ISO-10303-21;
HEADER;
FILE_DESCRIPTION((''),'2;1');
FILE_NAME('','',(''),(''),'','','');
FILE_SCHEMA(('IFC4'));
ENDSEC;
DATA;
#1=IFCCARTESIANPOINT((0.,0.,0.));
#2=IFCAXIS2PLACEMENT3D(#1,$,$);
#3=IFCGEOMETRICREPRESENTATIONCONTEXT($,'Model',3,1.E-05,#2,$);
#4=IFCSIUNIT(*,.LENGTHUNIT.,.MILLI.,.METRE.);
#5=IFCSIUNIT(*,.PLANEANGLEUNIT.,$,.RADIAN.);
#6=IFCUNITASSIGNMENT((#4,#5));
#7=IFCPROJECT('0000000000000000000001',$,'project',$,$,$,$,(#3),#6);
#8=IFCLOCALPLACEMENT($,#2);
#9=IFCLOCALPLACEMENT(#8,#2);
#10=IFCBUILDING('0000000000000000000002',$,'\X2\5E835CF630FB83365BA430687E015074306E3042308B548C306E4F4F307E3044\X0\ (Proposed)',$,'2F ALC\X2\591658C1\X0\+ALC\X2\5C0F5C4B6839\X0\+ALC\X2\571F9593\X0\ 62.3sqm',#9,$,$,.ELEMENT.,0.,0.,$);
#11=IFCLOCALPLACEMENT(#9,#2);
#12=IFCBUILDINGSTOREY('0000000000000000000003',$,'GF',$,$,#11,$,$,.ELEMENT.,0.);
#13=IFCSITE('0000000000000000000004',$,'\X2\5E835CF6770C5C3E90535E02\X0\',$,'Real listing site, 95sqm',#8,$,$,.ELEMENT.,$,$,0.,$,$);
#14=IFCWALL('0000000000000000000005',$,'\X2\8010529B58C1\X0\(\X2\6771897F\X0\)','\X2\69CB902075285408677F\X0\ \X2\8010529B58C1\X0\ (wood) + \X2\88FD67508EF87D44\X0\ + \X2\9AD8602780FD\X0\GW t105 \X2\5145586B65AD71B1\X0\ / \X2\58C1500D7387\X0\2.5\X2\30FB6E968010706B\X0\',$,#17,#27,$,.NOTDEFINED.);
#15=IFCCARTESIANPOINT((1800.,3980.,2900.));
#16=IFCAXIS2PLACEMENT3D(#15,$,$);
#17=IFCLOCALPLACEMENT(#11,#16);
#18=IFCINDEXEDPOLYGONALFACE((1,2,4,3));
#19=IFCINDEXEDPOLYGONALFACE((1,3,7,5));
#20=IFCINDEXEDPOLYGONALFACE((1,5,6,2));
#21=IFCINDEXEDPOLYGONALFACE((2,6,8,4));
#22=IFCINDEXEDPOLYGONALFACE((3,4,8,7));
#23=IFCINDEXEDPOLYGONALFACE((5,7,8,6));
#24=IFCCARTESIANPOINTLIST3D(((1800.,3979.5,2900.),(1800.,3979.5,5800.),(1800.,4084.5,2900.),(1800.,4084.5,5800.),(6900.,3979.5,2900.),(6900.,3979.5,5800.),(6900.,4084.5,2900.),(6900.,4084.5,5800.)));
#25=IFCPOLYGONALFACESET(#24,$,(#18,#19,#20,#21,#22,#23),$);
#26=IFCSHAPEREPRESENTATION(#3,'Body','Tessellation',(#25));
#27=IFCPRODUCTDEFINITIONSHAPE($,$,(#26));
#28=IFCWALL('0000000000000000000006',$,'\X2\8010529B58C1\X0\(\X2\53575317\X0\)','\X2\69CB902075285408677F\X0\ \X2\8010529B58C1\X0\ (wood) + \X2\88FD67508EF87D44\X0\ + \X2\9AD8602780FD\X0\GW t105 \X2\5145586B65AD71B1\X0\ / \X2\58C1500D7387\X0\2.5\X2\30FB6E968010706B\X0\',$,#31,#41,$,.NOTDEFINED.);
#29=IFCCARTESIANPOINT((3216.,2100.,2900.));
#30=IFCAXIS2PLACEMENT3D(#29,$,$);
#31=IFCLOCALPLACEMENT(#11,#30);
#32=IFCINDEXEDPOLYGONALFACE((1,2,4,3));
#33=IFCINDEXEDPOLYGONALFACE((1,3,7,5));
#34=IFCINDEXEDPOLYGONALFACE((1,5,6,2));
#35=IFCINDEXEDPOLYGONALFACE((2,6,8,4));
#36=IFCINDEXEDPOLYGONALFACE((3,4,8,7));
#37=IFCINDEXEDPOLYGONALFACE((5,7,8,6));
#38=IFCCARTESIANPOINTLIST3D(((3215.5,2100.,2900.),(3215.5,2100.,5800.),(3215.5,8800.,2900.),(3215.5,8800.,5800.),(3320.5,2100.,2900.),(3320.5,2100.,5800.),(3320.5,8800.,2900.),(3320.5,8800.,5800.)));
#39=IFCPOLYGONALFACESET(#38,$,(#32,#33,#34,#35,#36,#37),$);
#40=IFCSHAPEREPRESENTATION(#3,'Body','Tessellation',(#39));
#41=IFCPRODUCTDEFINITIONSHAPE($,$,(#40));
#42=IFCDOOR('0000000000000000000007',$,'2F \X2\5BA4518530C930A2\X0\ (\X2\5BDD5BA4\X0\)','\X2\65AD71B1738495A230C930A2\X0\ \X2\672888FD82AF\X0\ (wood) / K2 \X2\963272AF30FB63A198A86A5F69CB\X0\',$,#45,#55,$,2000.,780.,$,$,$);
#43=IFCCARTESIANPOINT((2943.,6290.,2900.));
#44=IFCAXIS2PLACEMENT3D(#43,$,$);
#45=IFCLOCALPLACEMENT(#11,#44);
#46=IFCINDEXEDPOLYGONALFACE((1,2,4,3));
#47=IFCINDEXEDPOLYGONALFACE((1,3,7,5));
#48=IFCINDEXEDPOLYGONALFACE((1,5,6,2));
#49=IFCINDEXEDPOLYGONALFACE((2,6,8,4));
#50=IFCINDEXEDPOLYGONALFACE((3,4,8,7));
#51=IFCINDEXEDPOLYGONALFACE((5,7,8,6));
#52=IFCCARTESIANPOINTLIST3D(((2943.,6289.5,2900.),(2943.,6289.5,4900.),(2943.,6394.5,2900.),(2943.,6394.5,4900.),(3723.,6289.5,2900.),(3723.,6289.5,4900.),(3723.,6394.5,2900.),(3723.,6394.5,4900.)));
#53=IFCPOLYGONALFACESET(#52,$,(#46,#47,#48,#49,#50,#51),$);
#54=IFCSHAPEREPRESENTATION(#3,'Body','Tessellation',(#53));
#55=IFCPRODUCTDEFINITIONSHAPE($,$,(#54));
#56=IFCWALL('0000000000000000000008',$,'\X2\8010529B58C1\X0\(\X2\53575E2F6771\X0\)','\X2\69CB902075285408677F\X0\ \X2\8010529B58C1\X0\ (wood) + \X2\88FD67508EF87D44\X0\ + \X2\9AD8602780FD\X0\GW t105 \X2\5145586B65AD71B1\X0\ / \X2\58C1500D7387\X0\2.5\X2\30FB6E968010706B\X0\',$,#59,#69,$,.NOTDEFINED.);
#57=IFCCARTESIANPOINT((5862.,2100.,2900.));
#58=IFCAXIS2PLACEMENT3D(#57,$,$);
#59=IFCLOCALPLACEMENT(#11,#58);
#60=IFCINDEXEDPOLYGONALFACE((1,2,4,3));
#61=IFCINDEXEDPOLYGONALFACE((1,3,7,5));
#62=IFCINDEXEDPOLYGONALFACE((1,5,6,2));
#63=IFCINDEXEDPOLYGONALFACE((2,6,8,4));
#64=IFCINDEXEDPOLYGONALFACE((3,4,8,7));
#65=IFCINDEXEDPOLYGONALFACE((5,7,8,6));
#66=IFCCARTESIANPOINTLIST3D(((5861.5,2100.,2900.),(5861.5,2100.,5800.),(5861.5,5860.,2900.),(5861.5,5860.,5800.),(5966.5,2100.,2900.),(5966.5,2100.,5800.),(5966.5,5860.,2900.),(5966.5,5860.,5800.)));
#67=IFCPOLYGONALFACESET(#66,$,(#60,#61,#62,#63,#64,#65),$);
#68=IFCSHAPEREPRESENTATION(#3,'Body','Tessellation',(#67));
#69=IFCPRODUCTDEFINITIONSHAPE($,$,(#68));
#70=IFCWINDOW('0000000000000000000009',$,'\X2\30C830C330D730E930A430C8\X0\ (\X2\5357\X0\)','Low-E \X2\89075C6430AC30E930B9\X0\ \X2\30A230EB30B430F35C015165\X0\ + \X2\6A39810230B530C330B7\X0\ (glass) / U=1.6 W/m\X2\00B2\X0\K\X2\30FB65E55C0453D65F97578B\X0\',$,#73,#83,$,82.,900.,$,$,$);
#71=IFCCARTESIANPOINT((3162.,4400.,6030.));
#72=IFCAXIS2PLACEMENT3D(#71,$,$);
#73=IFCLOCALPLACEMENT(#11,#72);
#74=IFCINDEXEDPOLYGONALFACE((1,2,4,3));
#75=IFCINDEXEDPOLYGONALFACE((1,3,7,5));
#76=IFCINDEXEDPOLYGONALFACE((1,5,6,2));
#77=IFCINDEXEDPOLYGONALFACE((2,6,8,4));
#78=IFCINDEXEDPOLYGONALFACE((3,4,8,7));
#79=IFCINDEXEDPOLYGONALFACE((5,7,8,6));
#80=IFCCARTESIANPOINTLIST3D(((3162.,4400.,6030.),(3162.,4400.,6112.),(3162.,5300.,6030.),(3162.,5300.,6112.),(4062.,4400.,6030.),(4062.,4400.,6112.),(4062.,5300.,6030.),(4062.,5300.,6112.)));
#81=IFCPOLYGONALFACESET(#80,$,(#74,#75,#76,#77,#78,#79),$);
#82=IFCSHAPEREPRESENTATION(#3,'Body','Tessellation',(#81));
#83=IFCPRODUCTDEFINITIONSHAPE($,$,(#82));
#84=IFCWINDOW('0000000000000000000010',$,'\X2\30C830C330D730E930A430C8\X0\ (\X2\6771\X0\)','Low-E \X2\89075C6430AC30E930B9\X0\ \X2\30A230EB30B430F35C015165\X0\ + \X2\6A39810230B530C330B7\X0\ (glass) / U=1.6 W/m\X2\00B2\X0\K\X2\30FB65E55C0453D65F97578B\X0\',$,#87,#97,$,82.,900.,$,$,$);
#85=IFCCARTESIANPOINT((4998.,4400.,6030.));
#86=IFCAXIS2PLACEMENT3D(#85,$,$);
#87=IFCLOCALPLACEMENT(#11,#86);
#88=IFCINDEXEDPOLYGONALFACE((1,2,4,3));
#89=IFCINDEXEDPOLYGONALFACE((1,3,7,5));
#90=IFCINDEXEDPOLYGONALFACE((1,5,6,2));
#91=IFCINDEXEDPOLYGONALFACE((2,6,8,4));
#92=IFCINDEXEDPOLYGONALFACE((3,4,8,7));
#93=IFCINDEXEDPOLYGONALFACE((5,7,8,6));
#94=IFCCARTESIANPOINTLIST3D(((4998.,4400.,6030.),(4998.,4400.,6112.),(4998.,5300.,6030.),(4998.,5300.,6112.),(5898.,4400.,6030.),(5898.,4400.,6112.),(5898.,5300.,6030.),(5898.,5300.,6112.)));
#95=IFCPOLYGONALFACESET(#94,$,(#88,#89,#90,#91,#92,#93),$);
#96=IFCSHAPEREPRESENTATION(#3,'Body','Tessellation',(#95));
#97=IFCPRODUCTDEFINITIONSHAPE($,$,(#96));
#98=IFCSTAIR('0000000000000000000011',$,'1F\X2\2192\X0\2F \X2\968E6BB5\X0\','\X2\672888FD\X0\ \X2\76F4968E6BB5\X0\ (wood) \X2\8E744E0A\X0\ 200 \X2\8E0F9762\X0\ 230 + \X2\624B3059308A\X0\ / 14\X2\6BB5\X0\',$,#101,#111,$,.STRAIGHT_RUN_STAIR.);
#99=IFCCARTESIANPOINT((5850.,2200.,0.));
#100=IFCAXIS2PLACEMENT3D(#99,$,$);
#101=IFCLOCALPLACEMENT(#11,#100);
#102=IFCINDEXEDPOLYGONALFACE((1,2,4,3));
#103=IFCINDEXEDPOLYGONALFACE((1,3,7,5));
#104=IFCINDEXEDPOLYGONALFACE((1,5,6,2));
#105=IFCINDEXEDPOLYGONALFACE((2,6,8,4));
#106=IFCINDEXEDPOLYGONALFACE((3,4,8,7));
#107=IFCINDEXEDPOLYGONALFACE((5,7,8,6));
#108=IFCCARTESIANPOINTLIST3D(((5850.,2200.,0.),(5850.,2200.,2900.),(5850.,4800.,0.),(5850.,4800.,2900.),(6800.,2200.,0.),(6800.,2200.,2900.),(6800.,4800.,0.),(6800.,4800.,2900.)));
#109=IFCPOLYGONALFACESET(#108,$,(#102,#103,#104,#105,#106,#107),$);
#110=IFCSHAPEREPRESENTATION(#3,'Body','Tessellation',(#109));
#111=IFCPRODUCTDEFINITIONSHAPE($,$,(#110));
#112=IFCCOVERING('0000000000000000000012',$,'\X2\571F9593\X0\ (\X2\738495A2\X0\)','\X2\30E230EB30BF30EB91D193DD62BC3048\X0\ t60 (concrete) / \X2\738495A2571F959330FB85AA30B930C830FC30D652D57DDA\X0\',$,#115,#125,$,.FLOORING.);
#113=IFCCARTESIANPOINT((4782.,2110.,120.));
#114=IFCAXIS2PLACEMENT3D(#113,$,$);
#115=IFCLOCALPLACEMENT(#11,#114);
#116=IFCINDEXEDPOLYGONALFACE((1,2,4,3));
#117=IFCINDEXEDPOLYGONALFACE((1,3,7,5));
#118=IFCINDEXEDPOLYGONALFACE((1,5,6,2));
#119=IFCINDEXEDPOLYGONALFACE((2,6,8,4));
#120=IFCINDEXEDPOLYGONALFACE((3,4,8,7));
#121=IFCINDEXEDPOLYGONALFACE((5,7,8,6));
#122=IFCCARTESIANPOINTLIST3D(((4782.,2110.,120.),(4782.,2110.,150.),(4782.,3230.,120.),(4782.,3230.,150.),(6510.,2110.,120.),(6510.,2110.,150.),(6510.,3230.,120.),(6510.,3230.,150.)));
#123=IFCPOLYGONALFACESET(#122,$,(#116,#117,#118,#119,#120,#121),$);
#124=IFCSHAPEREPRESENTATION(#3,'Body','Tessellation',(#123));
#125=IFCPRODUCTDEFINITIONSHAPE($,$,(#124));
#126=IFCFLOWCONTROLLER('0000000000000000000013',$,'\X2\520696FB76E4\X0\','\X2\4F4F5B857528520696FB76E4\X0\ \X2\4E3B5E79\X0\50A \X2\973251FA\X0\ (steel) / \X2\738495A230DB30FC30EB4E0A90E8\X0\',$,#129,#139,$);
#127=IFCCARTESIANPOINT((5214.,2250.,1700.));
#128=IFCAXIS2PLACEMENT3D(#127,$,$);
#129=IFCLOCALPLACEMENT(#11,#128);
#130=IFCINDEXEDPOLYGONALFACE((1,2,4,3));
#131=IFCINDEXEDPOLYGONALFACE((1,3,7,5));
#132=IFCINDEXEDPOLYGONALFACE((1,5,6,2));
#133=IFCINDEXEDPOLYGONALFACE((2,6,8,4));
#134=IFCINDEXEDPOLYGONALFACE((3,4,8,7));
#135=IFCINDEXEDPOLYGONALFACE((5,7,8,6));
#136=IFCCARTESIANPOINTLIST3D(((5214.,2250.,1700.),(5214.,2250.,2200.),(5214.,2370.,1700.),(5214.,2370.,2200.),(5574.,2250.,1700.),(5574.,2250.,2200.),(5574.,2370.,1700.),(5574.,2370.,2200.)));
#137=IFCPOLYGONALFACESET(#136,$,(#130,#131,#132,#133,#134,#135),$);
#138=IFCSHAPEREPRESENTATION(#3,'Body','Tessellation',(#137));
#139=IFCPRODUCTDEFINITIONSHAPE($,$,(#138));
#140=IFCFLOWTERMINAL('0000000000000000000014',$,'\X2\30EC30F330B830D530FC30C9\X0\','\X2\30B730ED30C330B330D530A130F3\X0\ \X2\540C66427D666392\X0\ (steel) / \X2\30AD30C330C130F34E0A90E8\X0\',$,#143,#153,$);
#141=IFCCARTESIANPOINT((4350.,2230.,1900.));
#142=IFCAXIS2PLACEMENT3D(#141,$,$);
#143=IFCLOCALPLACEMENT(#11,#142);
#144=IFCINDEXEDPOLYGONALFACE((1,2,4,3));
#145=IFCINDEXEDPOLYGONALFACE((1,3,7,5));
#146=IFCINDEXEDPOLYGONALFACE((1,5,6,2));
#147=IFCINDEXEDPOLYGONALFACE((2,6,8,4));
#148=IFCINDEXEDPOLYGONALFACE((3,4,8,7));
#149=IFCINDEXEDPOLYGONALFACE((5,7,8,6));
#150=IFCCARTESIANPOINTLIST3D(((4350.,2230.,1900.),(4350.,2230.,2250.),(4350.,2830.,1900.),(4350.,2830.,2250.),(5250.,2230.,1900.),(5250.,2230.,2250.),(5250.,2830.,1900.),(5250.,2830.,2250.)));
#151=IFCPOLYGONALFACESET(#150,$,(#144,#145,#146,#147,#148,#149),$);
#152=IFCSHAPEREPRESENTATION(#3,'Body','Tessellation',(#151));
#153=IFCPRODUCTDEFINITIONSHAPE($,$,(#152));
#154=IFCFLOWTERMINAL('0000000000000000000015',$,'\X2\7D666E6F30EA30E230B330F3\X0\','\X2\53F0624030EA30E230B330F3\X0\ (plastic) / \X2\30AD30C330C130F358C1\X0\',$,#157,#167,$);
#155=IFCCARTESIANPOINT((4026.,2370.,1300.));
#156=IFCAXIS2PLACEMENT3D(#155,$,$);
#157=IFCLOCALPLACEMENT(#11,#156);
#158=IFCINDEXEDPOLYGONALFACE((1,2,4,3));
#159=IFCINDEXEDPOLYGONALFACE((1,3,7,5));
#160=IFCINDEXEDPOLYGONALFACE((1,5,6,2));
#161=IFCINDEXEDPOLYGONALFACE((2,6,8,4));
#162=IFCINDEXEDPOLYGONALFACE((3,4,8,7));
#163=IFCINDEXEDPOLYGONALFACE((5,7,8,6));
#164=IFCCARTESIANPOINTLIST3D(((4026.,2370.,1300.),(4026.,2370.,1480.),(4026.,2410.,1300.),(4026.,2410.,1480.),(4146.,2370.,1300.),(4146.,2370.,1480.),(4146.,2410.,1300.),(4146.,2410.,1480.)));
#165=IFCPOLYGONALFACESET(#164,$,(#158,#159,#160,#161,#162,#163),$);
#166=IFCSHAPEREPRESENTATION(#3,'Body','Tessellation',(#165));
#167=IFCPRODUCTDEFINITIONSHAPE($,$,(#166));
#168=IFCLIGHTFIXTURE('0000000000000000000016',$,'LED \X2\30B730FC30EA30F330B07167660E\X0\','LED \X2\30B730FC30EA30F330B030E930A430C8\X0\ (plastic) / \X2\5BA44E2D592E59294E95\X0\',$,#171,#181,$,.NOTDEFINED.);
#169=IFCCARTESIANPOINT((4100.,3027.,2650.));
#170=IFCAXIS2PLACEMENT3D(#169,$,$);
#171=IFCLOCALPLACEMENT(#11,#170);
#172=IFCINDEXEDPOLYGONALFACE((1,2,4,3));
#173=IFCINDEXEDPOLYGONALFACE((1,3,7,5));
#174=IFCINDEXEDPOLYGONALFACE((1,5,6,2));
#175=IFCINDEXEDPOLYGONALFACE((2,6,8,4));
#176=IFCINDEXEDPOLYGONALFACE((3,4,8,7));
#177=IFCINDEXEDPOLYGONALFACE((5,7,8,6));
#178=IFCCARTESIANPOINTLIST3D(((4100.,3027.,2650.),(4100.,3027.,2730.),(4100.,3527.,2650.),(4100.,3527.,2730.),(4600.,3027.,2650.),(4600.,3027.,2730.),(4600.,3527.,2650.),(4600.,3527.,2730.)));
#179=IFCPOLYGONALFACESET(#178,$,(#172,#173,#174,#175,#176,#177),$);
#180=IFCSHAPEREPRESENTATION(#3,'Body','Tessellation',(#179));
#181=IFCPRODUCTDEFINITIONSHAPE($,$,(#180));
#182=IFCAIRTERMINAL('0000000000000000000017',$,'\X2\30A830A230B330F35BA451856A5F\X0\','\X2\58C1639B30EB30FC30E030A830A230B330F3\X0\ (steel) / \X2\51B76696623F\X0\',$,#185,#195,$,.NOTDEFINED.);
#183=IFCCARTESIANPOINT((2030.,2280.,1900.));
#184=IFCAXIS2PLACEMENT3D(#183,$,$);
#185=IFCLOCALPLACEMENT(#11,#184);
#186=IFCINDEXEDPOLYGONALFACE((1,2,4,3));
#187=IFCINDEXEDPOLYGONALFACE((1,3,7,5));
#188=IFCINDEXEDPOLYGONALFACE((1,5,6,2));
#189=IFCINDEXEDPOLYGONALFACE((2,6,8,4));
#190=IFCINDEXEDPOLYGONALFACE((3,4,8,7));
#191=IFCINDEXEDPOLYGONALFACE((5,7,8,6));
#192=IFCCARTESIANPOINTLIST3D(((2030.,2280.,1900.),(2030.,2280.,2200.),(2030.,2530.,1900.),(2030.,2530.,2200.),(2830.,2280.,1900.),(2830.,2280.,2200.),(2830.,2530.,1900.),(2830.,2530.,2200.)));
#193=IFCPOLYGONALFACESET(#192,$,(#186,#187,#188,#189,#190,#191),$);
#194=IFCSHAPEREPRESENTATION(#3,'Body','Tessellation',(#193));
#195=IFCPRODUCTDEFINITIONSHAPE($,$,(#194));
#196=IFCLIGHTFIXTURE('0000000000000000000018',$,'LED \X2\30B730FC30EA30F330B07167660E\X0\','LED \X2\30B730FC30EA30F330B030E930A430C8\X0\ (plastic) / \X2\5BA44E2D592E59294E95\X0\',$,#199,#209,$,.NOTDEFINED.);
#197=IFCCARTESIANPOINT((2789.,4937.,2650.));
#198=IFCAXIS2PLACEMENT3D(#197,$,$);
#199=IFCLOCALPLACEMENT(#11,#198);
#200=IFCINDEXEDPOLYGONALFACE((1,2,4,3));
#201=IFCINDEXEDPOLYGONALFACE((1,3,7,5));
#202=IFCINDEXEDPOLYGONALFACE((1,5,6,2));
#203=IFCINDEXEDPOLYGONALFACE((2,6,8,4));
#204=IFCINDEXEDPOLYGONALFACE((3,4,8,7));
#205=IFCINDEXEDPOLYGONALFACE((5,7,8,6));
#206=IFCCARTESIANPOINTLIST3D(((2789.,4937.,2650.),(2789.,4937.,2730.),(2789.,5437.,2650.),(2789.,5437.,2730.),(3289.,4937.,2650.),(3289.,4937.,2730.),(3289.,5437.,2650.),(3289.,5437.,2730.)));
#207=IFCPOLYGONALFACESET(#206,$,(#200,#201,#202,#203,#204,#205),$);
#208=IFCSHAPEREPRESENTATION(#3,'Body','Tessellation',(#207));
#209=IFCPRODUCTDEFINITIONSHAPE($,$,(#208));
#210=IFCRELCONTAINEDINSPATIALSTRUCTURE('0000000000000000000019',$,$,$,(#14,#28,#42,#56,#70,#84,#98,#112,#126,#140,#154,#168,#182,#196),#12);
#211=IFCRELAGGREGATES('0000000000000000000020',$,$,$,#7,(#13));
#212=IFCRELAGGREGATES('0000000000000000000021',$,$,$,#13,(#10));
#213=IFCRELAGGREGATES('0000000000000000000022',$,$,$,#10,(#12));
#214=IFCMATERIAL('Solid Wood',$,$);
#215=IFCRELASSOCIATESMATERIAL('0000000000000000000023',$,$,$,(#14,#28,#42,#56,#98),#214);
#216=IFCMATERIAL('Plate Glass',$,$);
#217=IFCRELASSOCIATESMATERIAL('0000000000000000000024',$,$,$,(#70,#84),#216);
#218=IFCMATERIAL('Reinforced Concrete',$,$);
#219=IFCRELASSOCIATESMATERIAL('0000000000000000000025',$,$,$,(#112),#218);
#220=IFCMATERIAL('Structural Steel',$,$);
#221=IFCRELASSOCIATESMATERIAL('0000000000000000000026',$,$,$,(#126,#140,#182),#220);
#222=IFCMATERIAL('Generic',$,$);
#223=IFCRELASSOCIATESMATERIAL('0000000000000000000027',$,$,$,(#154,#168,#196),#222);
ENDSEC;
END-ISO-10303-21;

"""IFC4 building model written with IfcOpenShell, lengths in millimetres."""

from ifc_helpers import new_model, si_unit, frame, frame_2d, origin, place, context, project, spatial, rectangle, extrude, material, element, fill, save


model = new_model("IFC4")

# Units and contexts
model_context = context("Model", 3, precision=1e-05, world=origin())
ifc_project = project(units=[si_unit("LENGTHUNIT", "METRE", prefix="MILLI"), si_unit("PLANEANGLEUNIT", "RADIAN")], contexts=[model_context])

# Site, building, storey
site_placement = place(None, origin())
site = spatial("IfcSite", under=ifc_project, at=site_placement, Name="広島県尾道市", ObjectType="Real listing site, 95sqm", CompositionType="ELEMENT", RefElevation=0.0)
building_placement = place(site_placement, origin())
building = spatial("IfcBuilding", under=site, at=building_placement, Name="広島・茶室と縁側のある和の住まい (Proposed)", ObjectType="2F ALC外壁+ALC小屋根+ALC土間 62.3sqm", CompositionType="ELEMENT", ElevationOfRefHeight=0.0, ElevationOfTerrain=0.0)
storey_placement = place(building_placement, origin())
storey = spatial("IfcBuildingStorey", under=building, at=storey_placement, Name="GF", CompositionType="ELEMENT", Elevation=0.0)

# Shared definitions
ifc_material_1 = material(Name="Solid Wood")

# Wall
wall_1_placement = place(storey_placement, frame((1800.0, 3980.0, 2900.0)))
element("IfcWall", 1, at=wall_1_placement, inside=storey, material=ifc_material_1, Name="耐力壁(東西)", Description="構造用合板 耐力壁 (wood) + 製材軸組 + 高性能GW t105 充填断熱 / 壁倍率2.5・準耐火", PredefinedType="NOTDEFINED", context=model_context, shape_type="SweptSolid", body=[
    extrude(rectangle(XDim=5100.0, YDim=105.0, at=frame_2d((2550.0, 52.0))), frame((1800.0, 3980.0, 2900.0)), (0.0, 0.0, 1.0), 2900.0),
])

# Wall, opening, door
wall_2_placement = place(storey_placement, frame((3216.0, 2100.0, 2900.0)))
wall_2 = element("IfcWall", 2, at=wall_2_placement, inside=storey, material=ifc_material_1, Name="耐力壁(南北)", Description="構造用合板 耐力壁 (wood) + 製材軸組 + 高性能GW t105 充填断熱 / 壁倍率2.5・準耐火", PredefinedType="NOTDEFINED", context=model_context, shape_type="SweptSolid", body=[
    extrude(rectangle(XDim=105.0, YDim=6700.0, at=frame_2d((52.0, 3350.0))), frame((3216.0, 2100.0, 2900.0)), (0.0, 0.0, 1.0), 2900.0),
])
opening_placement = place(storey_placement, frame((2943.0, 6290.0, 2900.0)))
opening = element("IfcOpeningElement", 3, at=opening_placement, cuts=wall_2, PredefinedType="NOTDEFINED", context=model_context, shape_type="SweptSolid", body=[
    extrude(rectangle(XDim=780.0, YDim=105.0, at=frame_2d((390.0, 52.0))), frame((2943.0, 6290.0, 2900.0)), (0.0, 0.0, 1.0), 2000.0),
])
door_placement = place(storey_placement, frame((2943.0, 6290.0, 2900.0)))
door = element("IfcDoor", 4, at=door_placement, inside=storey, material=ifc_material_1, Name="2F 室内ドア (寝室)", Description="断熱玄関ドア 木製芯 (wood) / K2 防犯・採風機構", OverallHeight=2000.0, OverallWidth=780.0, context=model_context, shape_type="SweptSolid", body=[
    extrude(rectangle(XDim=780.0, YDim=105.0, at=frame_2d((390.0, 52.0))), frame((2943.0, 6290.0, 2900.0)), (0.0, 0.0, 1.0), 2000.0),
])
fill(opening, door)

# Wall
wall_3_placement = place(storey_placement, frame((5862.0, 2100.0, 2900.0)))
element("IfcWall", 5, at=wall_3_placement, inside=storey, material=ifc_material_1, Name="耐力壁(南帯東)", Description="構造用合板 耐力壁 (wood) + 製材軸組 + 高性能GW t105 充填断熱 / 壁倍率2.5・準耐火", PredefinedType="NOTDEFINED", context=model_context, shape_type="SweptSolid", body=[
    extrude(rectangle(XDim=105.0, YDim=3760.0, at=frame_2d((52.0, 1880.0))), frame((5862.0, 2100.0, 2900.0)), (0.0, 0.0, 1.0), 2900.0),
])

# Windows
ifc_material_2 = material(Name="Plate Glass")
window_1_placement = place(storey_placement, frame((3162.0, 4400.0, 6030.0)))
element("IfcWindow", 6, at=window_1_placement, inside=storey, material=ifc_material_2, Name="トップライト (南)", Description="Low-E 複層ガラス アルゴン封入 + 樹脂サッシ (glass) / U=1.6 W/m²K・日射取得型", OverallHeight=82.0, OverallWidth=900.0, context=model_context, shape_type="SweptSolid", body=[
    extrude(rectangle(XDim=900.0, YDim=900.0, at=frame_2d((450.0, 450.0))), frame((3162.0, 4400.0, 6030.0)), (0.0, 0.0, 1.0), 82.0),
])
window_2_placement = place(storey_placement, frame((4998.0, 4400.0, 6030.0)))
element("IfcWindow", 7, at=window_2_placement, inside=storey, material=ifc_material_2, Name="トップライト (東)", Description="Low-E 複層ガラス アルゴン封入 + 樹脂サッシ (glass) / U=1.6 W/m²K・日射取得型", OverallHeight=82.0, OverallWidth=900.0, context=model_context, shape_type="SweptSolid", body=[
    extrude(rectangle(XDim=900.0, YDim=900.0, at=frame_2d((450.0, 450.0))), frame((4998.0, 4400.0, 6030.0)), (0.0, 0.0, 1.0), 82.0),
])

# Stair
stair_placement = place(storey_placement, frame((5850.0, 2200.0, 0.0)))
element("IfcStair", 8, at=stair_placement, inside=storey, material=ifc_material_1, Name="1F→2F 階段", Description="木製 直階段 (wood) 蹴上 200 踏面 230 + 手すり / 14段", PredefinedType="STRAIGHT_RUN_STAIR", context=model_context, shape_type="SweptSolid", body=[
    extrude(rectangle(XDim=950.0, YDim=2600.0, at=frame_2d((475.0, 1300.0))), frame((5850.0, 2200.0, 0.0)), (0.0, 0.0, 1.0), 2900.0),
])

# Covering
ifc_material_3 = material(Name="Reinforced Concrete")
covering_placement = place(storey_placement, frame((4782.0, 2110.0, 120.0)))
element("IfcCovering", 9, at=covering_placement, inside=storey, material=ifc_material_3, Name="土間 (玄関)", Description="モルタル金鏝押え t60 (concrete) / 玄関土間・薪ストーブ動線", PredefinedType="FLOORING", context=model_context, shape_type="SweptSolid", body=[
    extrude(rectangle(XDim=1728.0, YDim=1120.0, at=frame_2d((864.0, 560.0))), frame((4782.0, 2110.0, 120.0)), (0.0, 0.0, 1.0), 30.0),
])

# Shared definitions
ifc_material_4 = material(Name="Structural Steel")

# Flow controller
flow_controller_placement = place(storey_placement, frame((5214.0, 2250.0, 1700.0)))
element("IfcFlowController", 10, at=flow_controller_placement, inside=storey, material=ifc_material_4, Name="分電盤", Description="住宅用分電盤 主幹50A 露出 (steel) / 玄関ホール上部", context=model_context, shape_type="SweptSolid", body=[
    extrude(rectangle(XDim=360.0, YDim=120.0, at=frame_2d((180.0, 60.0))), frame((5214.0, 2250.0, 1700.0)), (0.0, 0.0, 1.0), 500.0),
])

# Flow terminals
flow_terminal_1_placement = place(storey_placement, frame((4350.0, 2230.0, 1900.0)))
element("IfcFlowTerminal", 11, at=flow_terminal_1_placement, inside=storey, material=ifc_material_4, Name="レンジフード", Description="シロッコファン 同時給排 (steel) / キッチン上部", context=model_context, shape_type="SweptSolid", body=[
    extrude(rectangle(XDim=900.0, YDim=600.0, at=frame_2d((450.0, 300.0))), frame((4350.0, 2230.0, 1900.0)), (0.0, 0.0, 1.0), 350.0),
])
ifc_material_5 = material(Name="Generic")
flow_terminal_2_placement = place(storey_placement, frame((4026.0, 2370.0, 1300.0)))
element("IfcFlowTerminal", 12, at=flow_terminal_2_placement, inside=storey, material=ifc_material_5, Name="給湯リモコン", Description="台所リモコン (plastic) / キッチン壁", context=model_context, shape_type="SweptSolid", body=[
    extrude(rectangle(XDim=120.0, YDim=40.0, at=frame_2d((60.0, 20.0))), frame((4026.0, 2370.0, 1300.0)), (0.0, 0.0, 1.0), 180.0),
])

# Light fixture
light_fixture_1_placement = place(storey_placement, frame((4100.0, 3027.0, 2650.0)))
element("IfcLightFixture", 13, at=light_fixture_1_placement, inside=storey, material=ifc_material_5, Name="LED シーリング照明", Description="LED シーリングライト (plastic) / 室中央天井", PredefinedType="NOTDEFINED", context=model_context, shape_type="SweptSolid", body=[
    extrude(rectangle(XDim=500.0, YDim=500.0, at=frame_2d((250.0, 250.0))), frame((4100.0, 3027.0, 2650.0)), (0.0, 0.0, 1.0), 80.0),
])

# Air terminal
air_terminal_1_placement = place(storey_placement, frame((2030.0, 2280.0, 1900.0)))
element("IfcAirTerminal", 14, at=air_terminal_1_placement, inside=storey, material=ifc_material_4, Name="エアコン室内機", Description="壁掛ルームエアコン (steel) / 冷暖房", PredefinedType="NOTDEFINED", context=model_context, shape_type="SweptSolid", body=[
    extrude(rectangle(XDim=800.0, YDim=250.0, at=frame_2d((400.0, 125.0))), frame((2030.0, 2280.0, 1900.0)), (0.0, 0.0, 1.0), 300.0),
])

# Light fixture
light_fixture_2_placement = place(storey_placement, frame((2789.0, 4937.0, 2650.0)))
element("IfcLightFixture", 15, at=light_fixture_2_placement, inside=storey, material=ifc_material_5, Name="LED シーリング照明", Description="LED シーリングライト (plastic) / 室中央天井", PredefinedType="NOTDEFINED", context=model_context, shape_type="SweptSolid", body=[
    extrude(rectangle(XDim=500.0, YDim=500.0, at=frame_2d((250.0, 250.0))), frame((2789.0, 4937.0, 2650.0)), (0.0, 0.0, 1.0), 80.0),
])

save(model, "model.ifc")
